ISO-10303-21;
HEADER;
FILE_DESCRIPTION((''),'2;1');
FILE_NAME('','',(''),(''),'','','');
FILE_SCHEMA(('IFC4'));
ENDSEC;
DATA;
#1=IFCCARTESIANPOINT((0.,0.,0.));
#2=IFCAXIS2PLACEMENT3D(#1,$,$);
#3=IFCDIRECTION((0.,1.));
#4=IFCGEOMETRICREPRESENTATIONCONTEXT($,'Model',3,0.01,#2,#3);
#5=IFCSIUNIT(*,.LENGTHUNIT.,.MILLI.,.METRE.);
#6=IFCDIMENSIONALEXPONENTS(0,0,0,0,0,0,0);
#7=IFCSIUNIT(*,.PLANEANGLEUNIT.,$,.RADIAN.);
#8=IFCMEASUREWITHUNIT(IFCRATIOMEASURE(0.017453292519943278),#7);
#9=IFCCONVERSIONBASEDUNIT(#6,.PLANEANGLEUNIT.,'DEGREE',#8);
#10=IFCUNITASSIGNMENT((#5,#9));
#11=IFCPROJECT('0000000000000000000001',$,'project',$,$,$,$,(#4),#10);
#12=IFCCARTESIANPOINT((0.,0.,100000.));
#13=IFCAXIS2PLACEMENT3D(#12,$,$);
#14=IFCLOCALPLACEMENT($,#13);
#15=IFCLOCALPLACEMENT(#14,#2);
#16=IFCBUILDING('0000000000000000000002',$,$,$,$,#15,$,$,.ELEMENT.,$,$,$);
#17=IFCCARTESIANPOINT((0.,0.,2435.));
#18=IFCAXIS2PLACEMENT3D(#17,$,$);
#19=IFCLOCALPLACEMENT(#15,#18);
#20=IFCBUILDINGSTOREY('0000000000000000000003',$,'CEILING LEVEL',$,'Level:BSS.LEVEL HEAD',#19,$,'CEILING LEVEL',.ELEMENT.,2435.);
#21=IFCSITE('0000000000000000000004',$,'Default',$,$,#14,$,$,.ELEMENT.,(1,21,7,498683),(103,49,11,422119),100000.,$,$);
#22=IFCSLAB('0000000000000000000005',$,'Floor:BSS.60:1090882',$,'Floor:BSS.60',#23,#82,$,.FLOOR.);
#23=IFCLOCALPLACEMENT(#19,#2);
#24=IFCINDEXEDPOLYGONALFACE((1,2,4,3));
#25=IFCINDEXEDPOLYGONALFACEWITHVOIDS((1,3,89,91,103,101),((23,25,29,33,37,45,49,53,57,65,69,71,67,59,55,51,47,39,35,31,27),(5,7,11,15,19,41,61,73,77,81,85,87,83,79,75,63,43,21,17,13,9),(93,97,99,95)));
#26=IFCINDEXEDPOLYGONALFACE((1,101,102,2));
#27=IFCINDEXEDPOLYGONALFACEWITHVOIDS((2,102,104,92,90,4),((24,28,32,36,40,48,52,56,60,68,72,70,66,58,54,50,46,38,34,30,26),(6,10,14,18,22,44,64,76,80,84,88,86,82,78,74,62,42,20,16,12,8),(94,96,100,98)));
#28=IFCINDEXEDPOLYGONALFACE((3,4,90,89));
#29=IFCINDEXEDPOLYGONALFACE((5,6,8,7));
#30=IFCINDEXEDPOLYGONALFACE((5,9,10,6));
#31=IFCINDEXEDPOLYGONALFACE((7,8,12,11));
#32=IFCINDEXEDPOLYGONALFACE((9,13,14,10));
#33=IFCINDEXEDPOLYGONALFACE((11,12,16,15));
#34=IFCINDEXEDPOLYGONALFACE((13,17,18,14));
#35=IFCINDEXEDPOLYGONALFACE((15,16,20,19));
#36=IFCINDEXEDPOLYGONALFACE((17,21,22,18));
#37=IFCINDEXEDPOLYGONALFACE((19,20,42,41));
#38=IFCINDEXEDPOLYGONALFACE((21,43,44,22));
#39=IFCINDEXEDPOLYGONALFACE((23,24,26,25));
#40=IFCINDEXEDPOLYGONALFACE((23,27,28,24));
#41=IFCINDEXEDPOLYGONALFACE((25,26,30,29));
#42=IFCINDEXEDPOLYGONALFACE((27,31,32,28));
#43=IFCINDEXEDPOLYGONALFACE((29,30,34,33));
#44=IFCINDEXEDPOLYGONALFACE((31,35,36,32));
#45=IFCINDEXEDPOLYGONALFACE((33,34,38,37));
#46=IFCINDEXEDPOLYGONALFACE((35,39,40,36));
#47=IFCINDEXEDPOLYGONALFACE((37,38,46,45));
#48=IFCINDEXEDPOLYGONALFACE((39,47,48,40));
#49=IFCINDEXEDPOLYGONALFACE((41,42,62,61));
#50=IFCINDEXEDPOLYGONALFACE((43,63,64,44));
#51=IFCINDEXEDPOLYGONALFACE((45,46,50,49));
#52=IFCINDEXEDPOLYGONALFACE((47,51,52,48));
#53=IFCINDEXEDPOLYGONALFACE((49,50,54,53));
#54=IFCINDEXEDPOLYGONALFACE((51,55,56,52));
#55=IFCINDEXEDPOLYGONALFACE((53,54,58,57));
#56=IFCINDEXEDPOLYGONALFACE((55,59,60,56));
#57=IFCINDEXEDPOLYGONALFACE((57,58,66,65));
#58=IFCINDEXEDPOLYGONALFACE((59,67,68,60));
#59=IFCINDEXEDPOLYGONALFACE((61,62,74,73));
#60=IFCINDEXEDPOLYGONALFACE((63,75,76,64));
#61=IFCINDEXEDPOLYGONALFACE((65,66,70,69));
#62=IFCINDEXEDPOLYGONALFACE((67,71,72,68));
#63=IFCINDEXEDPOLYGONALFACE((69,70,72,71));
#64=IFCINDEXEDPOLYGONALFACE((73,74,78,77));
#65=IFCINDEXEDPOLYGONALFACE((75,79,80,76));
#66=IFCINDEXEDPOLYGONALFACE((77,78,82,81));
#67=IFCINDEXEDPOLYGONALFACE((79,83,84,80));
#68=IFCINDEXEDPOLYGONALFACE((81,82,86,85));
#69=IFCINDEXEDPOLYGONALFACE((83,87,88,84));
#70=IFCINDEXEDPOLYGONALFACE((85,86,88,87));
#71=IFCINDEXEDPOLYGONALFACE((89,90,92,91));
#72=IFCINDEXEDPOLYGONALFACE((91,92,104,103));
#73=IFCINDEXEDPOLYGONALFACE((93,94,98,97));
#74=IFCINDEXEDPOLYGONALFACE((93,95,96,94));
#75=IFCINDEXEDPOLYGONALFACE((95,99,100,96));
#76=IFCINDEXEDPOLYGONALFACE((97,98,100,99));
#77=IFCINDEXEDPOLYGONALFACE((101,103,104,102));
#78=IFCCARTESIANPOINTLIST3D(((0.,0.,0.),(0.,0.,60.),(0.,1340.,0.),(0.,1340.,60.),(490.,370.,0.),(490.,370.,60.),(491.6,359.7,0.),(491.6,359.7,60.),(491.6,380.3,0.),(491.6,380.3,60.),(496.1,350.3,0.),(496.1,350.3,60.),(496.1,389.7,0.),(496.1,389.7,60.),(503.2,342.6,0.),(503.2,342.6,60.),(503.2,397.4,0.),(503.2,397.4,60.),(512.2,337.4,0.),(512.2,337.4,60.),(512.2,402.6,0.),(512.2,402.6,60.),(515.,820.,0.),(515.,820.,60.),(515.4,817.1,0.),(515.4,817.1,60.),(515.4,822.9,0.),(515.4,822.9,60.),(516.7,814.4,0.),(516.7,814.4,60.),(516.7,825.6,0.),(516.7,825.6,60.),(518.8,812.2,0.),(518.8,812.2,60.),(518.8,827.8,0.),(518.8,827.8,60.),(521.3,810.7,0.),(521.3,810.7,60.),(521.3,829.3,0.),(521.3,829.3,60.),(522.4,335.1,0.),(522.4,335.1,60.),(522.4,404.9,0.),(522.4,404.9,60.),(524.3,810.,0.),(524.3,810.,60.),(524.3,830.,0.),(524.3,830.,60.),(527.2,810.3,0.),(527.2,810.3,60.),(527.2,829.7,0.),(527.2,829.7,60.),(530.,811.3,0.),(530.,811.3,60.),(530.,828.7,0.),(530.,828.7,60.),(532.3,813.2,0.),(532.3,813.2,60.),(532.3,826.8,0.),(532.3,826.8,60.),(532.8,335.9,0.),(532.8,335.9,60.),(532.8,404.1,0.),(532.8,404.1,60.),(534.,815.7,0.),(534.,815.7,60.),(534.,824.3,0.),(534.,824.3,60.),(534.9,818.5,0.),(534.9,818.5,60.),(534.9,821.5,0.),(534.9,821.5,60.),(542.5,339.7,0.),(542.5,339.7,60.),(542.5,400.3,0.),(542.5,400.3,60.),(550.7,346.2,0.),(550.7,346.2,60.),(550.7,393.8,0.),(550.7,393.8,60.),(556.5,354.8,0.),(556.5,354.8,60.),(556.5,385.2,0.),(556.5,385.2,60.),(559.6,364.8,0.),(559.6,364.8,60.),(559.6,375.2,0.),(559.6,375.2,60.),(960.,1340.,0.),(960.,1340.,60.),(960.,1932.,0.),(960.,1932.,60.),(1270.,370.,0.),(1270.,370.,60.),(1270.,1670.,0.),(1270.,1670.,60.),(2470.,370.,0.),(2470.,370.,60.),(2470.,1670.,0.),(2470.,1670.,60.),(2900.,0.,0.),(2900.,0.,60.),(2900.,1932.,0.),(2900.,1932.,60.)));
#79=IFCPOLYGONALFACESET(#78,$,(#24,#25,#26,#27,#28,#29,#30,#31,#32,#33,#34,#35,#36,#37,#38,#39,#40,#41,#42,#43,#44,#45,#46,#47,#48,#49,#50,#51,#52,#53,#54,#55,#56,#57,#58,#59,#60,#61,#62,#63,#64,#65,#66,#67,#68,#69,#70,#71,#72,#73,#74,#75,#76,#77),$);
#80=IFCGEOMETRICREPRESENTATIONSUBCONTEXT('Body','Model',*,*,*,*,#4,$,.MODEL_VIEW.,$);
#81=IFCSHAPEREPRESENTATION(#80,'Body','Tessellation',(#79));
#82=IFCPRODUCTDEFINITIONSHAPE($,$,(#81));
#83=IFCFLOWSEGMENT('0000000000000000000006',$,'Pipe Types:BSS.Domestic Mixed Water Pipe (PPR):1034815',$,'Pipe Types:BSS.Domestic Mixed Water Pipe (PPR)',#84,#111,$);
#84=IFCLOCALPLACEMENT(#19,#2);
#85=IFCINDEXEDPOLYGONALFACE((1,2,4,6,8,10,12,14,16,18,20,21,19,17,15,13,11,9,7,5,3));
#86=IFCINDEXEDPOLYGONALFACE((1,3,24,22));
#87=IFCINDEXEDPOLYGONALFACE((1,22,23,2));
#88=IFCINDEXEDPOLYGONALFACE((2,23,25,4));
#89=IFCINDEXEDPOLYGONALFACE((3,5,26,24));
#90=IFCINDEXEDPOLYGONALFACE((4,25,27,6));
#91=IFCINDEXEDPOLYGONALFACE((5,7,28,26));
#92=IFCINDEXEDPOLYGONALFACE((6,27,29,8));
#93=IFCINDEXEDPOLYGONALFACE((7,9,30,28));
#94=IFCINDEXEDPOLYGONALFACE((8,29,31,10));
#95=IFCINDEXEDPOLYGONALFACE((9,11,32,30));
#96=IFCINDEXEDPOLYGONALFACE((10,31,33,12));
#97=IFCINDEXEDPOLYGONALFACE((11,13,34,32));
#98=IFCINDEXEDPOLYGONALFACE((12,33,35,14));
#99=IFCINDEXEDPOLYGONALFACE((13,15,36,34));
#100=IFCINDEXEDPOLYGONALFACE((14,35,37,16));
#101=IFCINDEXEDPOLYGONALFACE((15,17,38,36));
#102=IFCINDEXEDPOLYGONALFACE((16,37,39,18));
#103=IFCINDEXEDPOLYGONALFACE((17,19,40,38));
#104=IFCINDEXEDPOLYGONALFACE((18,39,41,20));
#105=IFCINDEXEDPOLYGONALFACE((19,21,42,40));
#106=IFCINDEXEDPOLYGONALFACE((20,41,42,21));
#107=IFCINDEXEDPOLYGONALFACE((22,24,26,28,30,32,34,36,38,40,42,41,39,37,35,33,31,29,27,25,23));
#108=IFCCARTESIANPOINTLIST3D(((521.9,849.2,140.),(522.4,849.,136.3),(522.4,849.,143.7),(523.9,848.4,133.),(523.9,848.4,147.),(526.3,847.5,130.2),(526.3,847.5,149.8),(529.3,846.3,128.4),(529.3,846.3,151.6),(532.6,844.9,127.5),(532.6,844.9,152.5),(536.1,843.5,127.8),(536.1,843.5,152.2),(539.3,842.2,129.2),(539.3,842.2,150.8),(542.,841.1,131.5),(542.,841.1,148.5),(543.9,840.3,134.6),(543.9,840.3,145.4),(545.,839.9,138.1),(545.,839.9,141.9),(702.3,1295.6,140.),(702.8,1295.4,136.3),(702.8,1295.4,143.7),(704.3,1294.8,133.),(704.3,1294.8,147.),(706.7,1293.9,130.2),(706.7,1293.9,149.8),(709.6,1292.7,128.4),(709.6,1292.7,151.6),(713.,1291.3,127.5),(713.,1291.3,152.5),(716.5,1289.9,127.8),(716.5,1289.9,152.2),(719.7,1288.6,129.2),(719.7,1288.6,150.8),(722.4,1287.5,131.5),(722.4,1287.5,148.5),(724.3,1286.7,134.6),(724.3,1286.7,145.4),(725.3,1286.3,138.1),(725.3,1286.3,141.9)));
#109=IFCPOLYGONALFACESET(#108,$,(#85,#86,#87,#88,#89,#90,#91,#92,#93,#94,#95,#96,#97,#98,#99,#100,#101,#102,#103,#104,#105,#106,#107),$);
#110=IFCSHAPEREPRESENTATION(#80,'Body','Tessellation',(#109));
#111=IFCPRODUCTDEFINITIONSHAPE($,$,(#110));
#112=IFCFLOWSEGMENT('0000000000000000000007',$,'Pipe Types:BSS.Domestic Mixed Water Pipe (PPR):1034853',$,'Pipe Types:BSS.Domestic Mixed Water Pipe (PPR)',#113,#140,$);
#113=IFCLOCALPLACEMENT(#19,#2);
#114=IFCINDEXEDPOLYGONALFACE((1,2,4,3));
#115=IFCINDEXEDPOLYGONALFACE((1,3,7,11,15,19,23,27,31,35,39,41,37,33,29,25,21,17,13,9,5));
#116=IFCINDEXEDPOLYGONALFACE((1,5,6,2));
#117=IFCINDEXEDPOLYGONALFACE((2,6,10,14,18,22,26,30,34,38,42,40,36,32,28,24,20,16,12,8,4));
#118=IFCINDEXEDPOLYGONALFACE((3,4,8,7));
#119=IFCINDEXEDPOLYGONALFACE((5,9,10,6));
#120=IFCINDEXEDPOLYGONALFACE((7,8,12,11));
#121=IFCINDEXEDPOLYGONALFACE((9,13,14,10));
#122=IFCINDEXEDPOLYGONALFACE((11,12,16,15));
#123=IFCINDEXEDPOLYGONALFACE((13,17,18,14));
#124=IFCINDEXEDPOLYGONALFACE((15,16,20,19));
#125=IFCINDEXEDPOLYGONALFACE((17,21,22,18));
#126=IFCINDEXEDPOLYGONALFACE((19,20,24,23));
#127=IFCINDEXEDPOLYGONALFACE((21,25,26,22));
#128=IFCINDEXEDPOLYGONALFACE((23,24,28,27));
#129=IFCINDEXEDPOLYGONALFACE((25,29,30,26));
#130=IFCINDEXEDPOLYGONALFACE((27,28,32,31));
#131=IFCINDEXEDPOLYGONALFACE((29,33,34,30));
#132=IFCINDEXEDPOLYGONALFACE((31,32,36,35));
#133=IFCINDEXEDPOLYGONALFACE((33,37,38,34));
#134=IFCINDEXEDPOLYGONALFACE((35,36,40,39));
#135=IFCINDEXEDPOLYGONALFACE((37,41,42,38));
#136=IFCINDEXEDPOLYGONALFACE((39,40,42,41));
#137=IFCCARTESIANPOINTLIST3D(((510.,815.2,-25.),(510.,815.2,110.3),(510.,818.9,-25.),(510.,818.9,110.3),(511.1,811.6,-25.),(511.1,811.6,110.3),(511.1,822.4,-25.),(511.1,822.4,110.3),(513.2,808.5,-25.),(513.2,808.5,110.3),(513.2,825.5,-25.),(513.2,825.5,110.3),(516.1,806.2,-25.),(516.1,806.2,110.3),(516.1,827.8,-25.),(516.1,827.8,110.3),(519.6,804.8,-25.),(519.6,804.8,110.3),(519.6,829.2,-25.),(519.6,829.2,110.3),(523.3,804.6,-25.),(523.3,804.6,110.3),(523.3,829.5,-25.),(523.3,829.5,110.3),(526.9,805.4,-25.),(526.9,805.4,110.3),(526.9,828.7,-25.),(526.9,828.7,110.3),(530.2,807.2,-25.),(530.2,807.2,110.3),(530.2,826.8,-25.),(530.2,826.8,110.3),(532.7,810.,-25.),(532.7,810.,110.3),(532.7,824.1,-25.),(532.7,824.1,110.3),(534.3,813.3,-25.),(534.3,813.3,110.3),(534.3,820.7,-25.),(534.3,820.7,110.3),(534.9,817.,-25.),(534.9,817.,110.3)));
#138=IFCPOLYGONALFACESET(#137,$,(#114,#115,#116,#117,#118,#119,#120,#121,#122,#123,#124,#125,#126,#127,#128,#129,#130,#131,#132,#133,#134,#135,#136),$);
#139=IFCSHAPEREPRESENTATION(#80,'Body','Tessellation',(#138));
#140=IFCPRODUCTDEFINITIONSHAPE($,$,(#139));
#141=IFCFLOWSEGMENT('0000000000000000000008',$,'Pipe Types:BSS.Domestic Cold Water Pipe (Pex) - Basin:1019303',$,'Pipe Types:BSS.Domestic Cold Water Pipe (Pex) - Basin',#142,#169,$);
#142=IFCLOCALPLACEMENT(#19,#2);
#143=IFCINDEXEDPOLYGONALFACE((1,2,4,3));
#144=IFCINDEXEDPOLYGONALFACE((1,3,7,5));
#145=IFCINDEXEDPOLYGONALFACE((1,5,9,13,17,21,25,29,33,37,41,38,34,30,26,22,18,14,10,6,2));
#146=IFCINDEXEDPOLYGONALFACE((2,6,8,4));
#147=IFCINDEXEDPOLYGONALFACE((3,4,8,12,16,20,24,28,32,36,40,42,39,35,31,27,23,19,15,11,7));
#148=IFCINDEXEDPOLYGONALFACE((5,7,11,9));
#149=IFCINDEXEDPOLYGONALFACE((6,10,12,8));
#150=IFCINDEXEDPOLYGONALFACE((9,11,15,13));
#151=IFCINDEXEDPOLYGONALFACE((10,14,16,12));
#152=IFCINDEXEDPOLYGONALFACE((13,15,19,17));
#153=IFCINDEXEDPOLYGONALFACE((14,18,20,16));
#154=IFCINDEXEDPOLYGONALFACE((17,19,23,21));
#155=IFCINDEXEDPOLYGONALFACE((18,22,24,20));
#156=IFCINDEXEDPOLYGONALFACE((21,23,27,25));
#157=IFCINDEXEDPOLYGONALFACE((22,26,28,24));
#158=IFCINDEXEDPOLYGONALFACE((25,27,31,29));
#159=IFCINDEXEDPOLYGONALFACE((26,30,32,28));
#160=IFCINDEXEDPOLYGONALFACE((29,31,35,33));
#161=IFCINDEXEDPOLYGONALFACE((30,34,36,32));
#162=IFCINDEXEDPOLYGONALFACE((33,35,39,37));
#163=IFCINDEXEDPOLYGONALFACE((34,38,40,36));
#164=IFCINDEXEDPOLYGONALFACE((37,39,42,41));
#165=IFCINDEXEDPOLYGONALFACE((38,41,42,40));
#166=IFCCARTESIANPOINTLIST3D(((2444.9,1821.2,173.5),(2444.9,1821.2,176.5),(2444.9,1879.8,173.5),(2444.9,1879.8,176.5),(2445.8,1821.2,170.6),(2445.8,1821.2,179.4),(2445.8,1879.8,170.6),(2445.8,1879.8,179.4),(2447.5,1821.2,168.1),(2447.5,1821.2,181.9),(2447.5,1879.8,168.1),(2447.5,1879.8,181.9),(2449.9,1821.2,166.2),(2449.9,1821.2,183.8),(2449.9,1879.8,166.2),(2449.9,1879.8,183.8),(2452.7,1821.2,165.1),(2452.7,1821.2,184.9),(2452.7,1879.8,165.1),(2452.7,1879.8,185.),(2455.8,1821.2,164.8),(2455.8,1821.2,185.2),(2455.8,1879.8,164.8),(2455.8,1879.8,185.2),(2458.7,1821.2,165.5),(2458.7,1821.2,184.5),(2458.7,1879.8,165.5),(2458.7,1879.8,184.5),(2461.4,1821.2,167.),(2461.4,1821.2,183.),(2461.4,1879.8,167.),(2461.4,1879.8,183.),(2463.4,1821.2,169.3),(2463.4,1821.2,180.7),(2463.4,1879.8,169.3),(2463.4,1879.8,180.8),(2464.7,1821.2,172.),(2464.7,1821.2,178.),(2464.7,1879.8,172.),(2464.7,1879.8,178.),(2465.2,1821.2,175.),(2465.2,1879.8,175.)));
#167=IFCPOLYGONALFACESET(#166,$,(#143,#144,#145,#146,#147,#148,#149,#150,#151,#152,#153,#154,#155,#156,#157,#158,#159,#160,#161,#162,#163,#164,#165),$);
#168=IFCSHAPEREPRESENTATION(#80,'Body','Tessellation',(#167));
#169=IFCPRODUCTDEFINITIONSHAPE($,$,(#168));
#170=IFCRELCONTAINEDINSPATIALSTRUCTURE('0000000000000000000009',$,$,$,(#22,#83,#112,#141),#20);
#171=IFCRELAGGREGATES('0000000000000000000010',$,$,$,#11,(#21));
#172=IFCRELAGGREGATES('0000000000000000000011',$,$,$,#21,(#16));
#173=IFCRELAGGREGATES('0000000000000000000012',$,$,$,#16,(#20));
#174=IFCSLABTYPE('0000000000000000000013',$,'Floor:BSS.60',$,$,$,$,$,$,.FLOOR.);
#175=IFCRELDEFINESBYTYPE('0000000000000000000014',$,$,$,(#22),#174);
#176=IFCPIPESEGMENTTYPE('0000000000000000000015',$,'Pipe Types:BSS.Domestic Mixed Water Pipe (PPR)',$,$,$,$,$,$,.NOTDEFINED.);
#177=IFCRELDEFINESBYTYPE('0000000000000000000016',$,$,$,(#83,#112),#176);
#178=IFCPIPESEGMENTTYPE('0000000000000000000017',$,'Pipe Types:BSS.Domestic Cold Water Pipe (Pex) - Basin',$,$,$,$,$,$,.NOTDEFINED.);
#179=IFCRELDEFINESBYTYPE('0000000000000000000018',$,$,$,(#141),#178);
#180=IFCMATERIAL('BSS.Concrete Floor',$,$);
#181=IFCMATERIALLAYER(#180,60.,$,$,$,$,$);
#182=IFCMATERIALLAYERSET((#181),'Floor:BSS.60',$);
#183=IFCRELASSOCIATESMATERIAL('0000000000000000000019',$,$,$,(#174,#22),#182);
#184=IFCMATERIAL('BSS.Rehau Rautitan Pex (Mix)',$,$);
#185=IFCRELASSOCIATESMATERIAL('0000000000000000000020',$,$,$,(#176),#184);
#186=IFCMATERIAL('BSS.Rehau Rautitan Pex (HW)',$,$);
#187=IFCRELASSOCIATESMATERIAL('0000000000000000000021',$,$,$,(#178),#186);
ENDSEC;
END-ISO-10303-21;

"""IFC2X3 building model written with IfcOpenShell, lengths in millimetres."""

from ifc_helpers import new_model, entity, si_unit, converted_unit, direction, frame, frame_2d, origin, origin_2d_with_axis, place, context, subcontext, project, spatial, polyline, rectangle, circle, outline, extrude, material, layer, layer_set, layer_usage, type_object, element, save


model = new_model("IFC2X3")

# Units and contexts
model_context = context("Model", 3, precision=0.01, world=origin(), true_north=direction((0.0, 1.0)))
body_context = subcontext(model_context, "Body", "Model", "MODEL_VIEW")
ifc_project = project(units=[si_unit("LENGTHUNIT", "METRE", prefix="MILLI"), converted_unit("PLANEANGLEUNIT", "DEGREE", entity("IfcRatioMeasure", 0.017453292519943278), si_unit("PLANEANGLEUNIT", "RADIAN"), dimensions=[0, 0, 0, 0, 0, 0, 0])], contexts=[model_context])

# Site, building, storey
site_placement = place(None, frame((0.0, 0.0, 100000.0)))
site = spatial("IfcSite", under=ifc_project, at=site_placement, Name="Default", CompositionType="ELEMENT", RefLatitude=(1, 21, 7, 498683), RefLongitude=(103, 49, 11, 422119), RefElevation=100000.0)
building_placement = place(site_placement, origin())
building = spatial("IfcBuilding", under=site, at=building_placement, CompositionType="ELEMENT")
storey_placement = place(building_placement, frame((0.0, 0.0, 2435.0)))
storey = spatial("IfcBuildingStorey", under=building, at=storey_placement, Name="CEILING LEVEL", ObjectType="Level:BSS.LEVEL HEAD", LongName="CEILING LEVEL", CompositionType="ELEMENT", Elevation=2435.0)

# Slab, openings
ifc_material_1 = material(Name="BSS.Concrete Floor")
ifc_layer = layer(ifc_material_1, 60.0)
ifc_layer_set = layer_set([ifc_layer], Name="Floor:BSS.60")
ifc_layer_usage = layer_usage(ifc_layer_set, "AXIS3", "POSITIVE", 0.0)
slab_type = type_object("IfcSlabType", Name="Floor:BSS.60", PredefinedType="FLOOR", material=ifc_layer_set)
slab_placement = place(storey_placement, origin())
slab = element("IfcSlab", 1, at=slab_placement, inside=storey, type_object=slab_type, material=ifc_layer_usage, Name="Floor:BSS.60:1090882", ObjectType="Floor:BSS.60", PredefinedType="FLOOR", context=body_context, shape_type="SweptSolid", body=[
    extrude(outline(polyline([(-1450.0, -966.0), (1450.0, -966.0), (1450.0, 374.0), (490.0, 374.0), (490.0, 966.0), (-1450.0, 966.0), (-1450.0, -966.0)])), frame((1450.0, 966.0, 60.0), z_axis=(0.0, 0.0, -1.0), x_axis=(-1.0, 0.0, 0.0)), (0.0, 0.0, 1.0), 60.0),
])
opening_1_placement = place(slab_placement, frame((1870.0, 1020.0, 60.0)))
element("IfcOpeningElement", 2, at=opening_1_placement, cuts=slab, ObjectType="Opening", context=body_context, shape_type="SweptSolid", body=[
    extrude(rectangle(XDim=1200.0, YDim=1300.0, at=origin_2d_with_axis()), frame((0.0, 0.0, 0.0), z_axis=(0.0, 0.0, -1.0), x_axis=(1.0, 0.0, 0.0)), (0.0, 0.0, 1.0), 60.0),
])
opening_2_placement = place(slab_placement, frame((525.0, 820.0, 60.0)))
element("IfcOpeningElement", 3, at=opening_2_placement, cuts=slab, ObjectType="Opening", context=body_context, shape_type="SweptSolid", body=[
    extrude(circle(Radius=10.0, at=origin_2d_with_axis()), frame((0.0, 0.0, 0.0), z_axis=(0.0, 0.0, -1.0), x_axis=(-1.0, 0.0, 0.0)), (0.0, 0.0, 1.0), 60.0),
])
opening_3_placement = place(slab_placement, frame((525.0, 370.0, 60.0)))
element("IfcOpeningElement", 4, at=opening_3_placement, cuts=slab, ObjectType="Opening", context=body_context, shape_type="SweptSolid", body=[
    extrude(circle(Radius=35.0, at=origin_2d_with_axis()), frame((0.0, 0.0, 0.0), z_axis=(0.0, 0.0, -1.0), x_axis=(-1.0, 0.0, 0.0)), (0.0, 0.0, 1.0), 60.0),
])

# Flow segments
ifc_material_2 = material(Name="BSS.Rehau Rautitan Pex (Mix)")
pipe_segment_type_1 = type_object("IfcPipeSegmentType", Name="Pipe Types:BSS.Domestic Mixed Water Pipe (PPR)", PredefinedType="NOTDEFINED", material=ifc_material_2)
flow_segment_1_placement = place(storey_placement, origin())
element("IfcFlowSegment", 5, at=flow_segment_1_placement, inside=storey, type_object=pipe_segment_type_1, Name="Pipe Types:BSS.Domestic Mixed Water Pipe (PPR):1034815", ObjectType="Pipe Types:BSS.Domestic Mixed Water Pipe (PPR)", context=body_context, shape_type="SweptSolid", body=[
    extrude(circle(Radius=12.5, at=frame_2d((0.0, 0.0), x_axis=(1.0, 0.0))), frame((533.5, 844.5, 140.0), z_axis=(0.374644, 0.927169, 0.0), x_axis=(-0.927169, 0.374644, 0.000002)), (0.0, 0.0, 1.0), 481.5),
])
flow_segment_2_placement = place(storey_placement, origin())
element("IfcFlowSegment", 6, at=flow_segment_2_placement, inside=storey, type_object=pipe_segment_type_1, Name="Pipe Types:BSS.Domestic Mixed Water Pipe (PPR):1034853", ObjectType="Pipe Types:BSS.Domestic Mixed Water Pipe (PPR)", context=body_context, shape_type="SweptSolid", body=[
    extrude(circle(Radius=12.5, at=frame_2d((0.0, 0.0), x_axis=(1.0, 0.0))), frame((522.4, 817.0, -25.0)), (0.0, 0.0, 1.0), 135.3),
])
ifc_material_3 = material(Name="BSS.Rehau Rautitan Pex (HW)")
pipe_segment_type_2 = type_object("IfcPipeSegmentType", Name="Pipe Types:BSS.Domestic Cold Water Pipe (Pex) - Basin", PredefinedType="NOTDEFINED", material=ifc_material_3)
flow_segment_3_placement = place(storey_placement, origin())
element("IfcFlowSegment", 7, at=flow_segment_3_placement, inside=storey, type_object=pipe_segment_type_2, Name="Pipe Types:BSS.Domestic Cold Water Pipe (Pex) - Basin:1019303", ObjectType="Pipe Types:BSS.Domestic Cold Water Pipe (Pex) - Basin", context=body_context, shape_type="SweptSolid", body=[
    extrude(circle(Radius=10.2, at=origin_2d_with_axis()), frame((2455.0, 1821.2, 175.0), z_axis=(0.000003, 1.0, 0.000117), x_axis=(1.0, -0.000003, 0.0)), (0.0, 0.0, 1.0), 58.6),
])

save(model, "model.ifc")
